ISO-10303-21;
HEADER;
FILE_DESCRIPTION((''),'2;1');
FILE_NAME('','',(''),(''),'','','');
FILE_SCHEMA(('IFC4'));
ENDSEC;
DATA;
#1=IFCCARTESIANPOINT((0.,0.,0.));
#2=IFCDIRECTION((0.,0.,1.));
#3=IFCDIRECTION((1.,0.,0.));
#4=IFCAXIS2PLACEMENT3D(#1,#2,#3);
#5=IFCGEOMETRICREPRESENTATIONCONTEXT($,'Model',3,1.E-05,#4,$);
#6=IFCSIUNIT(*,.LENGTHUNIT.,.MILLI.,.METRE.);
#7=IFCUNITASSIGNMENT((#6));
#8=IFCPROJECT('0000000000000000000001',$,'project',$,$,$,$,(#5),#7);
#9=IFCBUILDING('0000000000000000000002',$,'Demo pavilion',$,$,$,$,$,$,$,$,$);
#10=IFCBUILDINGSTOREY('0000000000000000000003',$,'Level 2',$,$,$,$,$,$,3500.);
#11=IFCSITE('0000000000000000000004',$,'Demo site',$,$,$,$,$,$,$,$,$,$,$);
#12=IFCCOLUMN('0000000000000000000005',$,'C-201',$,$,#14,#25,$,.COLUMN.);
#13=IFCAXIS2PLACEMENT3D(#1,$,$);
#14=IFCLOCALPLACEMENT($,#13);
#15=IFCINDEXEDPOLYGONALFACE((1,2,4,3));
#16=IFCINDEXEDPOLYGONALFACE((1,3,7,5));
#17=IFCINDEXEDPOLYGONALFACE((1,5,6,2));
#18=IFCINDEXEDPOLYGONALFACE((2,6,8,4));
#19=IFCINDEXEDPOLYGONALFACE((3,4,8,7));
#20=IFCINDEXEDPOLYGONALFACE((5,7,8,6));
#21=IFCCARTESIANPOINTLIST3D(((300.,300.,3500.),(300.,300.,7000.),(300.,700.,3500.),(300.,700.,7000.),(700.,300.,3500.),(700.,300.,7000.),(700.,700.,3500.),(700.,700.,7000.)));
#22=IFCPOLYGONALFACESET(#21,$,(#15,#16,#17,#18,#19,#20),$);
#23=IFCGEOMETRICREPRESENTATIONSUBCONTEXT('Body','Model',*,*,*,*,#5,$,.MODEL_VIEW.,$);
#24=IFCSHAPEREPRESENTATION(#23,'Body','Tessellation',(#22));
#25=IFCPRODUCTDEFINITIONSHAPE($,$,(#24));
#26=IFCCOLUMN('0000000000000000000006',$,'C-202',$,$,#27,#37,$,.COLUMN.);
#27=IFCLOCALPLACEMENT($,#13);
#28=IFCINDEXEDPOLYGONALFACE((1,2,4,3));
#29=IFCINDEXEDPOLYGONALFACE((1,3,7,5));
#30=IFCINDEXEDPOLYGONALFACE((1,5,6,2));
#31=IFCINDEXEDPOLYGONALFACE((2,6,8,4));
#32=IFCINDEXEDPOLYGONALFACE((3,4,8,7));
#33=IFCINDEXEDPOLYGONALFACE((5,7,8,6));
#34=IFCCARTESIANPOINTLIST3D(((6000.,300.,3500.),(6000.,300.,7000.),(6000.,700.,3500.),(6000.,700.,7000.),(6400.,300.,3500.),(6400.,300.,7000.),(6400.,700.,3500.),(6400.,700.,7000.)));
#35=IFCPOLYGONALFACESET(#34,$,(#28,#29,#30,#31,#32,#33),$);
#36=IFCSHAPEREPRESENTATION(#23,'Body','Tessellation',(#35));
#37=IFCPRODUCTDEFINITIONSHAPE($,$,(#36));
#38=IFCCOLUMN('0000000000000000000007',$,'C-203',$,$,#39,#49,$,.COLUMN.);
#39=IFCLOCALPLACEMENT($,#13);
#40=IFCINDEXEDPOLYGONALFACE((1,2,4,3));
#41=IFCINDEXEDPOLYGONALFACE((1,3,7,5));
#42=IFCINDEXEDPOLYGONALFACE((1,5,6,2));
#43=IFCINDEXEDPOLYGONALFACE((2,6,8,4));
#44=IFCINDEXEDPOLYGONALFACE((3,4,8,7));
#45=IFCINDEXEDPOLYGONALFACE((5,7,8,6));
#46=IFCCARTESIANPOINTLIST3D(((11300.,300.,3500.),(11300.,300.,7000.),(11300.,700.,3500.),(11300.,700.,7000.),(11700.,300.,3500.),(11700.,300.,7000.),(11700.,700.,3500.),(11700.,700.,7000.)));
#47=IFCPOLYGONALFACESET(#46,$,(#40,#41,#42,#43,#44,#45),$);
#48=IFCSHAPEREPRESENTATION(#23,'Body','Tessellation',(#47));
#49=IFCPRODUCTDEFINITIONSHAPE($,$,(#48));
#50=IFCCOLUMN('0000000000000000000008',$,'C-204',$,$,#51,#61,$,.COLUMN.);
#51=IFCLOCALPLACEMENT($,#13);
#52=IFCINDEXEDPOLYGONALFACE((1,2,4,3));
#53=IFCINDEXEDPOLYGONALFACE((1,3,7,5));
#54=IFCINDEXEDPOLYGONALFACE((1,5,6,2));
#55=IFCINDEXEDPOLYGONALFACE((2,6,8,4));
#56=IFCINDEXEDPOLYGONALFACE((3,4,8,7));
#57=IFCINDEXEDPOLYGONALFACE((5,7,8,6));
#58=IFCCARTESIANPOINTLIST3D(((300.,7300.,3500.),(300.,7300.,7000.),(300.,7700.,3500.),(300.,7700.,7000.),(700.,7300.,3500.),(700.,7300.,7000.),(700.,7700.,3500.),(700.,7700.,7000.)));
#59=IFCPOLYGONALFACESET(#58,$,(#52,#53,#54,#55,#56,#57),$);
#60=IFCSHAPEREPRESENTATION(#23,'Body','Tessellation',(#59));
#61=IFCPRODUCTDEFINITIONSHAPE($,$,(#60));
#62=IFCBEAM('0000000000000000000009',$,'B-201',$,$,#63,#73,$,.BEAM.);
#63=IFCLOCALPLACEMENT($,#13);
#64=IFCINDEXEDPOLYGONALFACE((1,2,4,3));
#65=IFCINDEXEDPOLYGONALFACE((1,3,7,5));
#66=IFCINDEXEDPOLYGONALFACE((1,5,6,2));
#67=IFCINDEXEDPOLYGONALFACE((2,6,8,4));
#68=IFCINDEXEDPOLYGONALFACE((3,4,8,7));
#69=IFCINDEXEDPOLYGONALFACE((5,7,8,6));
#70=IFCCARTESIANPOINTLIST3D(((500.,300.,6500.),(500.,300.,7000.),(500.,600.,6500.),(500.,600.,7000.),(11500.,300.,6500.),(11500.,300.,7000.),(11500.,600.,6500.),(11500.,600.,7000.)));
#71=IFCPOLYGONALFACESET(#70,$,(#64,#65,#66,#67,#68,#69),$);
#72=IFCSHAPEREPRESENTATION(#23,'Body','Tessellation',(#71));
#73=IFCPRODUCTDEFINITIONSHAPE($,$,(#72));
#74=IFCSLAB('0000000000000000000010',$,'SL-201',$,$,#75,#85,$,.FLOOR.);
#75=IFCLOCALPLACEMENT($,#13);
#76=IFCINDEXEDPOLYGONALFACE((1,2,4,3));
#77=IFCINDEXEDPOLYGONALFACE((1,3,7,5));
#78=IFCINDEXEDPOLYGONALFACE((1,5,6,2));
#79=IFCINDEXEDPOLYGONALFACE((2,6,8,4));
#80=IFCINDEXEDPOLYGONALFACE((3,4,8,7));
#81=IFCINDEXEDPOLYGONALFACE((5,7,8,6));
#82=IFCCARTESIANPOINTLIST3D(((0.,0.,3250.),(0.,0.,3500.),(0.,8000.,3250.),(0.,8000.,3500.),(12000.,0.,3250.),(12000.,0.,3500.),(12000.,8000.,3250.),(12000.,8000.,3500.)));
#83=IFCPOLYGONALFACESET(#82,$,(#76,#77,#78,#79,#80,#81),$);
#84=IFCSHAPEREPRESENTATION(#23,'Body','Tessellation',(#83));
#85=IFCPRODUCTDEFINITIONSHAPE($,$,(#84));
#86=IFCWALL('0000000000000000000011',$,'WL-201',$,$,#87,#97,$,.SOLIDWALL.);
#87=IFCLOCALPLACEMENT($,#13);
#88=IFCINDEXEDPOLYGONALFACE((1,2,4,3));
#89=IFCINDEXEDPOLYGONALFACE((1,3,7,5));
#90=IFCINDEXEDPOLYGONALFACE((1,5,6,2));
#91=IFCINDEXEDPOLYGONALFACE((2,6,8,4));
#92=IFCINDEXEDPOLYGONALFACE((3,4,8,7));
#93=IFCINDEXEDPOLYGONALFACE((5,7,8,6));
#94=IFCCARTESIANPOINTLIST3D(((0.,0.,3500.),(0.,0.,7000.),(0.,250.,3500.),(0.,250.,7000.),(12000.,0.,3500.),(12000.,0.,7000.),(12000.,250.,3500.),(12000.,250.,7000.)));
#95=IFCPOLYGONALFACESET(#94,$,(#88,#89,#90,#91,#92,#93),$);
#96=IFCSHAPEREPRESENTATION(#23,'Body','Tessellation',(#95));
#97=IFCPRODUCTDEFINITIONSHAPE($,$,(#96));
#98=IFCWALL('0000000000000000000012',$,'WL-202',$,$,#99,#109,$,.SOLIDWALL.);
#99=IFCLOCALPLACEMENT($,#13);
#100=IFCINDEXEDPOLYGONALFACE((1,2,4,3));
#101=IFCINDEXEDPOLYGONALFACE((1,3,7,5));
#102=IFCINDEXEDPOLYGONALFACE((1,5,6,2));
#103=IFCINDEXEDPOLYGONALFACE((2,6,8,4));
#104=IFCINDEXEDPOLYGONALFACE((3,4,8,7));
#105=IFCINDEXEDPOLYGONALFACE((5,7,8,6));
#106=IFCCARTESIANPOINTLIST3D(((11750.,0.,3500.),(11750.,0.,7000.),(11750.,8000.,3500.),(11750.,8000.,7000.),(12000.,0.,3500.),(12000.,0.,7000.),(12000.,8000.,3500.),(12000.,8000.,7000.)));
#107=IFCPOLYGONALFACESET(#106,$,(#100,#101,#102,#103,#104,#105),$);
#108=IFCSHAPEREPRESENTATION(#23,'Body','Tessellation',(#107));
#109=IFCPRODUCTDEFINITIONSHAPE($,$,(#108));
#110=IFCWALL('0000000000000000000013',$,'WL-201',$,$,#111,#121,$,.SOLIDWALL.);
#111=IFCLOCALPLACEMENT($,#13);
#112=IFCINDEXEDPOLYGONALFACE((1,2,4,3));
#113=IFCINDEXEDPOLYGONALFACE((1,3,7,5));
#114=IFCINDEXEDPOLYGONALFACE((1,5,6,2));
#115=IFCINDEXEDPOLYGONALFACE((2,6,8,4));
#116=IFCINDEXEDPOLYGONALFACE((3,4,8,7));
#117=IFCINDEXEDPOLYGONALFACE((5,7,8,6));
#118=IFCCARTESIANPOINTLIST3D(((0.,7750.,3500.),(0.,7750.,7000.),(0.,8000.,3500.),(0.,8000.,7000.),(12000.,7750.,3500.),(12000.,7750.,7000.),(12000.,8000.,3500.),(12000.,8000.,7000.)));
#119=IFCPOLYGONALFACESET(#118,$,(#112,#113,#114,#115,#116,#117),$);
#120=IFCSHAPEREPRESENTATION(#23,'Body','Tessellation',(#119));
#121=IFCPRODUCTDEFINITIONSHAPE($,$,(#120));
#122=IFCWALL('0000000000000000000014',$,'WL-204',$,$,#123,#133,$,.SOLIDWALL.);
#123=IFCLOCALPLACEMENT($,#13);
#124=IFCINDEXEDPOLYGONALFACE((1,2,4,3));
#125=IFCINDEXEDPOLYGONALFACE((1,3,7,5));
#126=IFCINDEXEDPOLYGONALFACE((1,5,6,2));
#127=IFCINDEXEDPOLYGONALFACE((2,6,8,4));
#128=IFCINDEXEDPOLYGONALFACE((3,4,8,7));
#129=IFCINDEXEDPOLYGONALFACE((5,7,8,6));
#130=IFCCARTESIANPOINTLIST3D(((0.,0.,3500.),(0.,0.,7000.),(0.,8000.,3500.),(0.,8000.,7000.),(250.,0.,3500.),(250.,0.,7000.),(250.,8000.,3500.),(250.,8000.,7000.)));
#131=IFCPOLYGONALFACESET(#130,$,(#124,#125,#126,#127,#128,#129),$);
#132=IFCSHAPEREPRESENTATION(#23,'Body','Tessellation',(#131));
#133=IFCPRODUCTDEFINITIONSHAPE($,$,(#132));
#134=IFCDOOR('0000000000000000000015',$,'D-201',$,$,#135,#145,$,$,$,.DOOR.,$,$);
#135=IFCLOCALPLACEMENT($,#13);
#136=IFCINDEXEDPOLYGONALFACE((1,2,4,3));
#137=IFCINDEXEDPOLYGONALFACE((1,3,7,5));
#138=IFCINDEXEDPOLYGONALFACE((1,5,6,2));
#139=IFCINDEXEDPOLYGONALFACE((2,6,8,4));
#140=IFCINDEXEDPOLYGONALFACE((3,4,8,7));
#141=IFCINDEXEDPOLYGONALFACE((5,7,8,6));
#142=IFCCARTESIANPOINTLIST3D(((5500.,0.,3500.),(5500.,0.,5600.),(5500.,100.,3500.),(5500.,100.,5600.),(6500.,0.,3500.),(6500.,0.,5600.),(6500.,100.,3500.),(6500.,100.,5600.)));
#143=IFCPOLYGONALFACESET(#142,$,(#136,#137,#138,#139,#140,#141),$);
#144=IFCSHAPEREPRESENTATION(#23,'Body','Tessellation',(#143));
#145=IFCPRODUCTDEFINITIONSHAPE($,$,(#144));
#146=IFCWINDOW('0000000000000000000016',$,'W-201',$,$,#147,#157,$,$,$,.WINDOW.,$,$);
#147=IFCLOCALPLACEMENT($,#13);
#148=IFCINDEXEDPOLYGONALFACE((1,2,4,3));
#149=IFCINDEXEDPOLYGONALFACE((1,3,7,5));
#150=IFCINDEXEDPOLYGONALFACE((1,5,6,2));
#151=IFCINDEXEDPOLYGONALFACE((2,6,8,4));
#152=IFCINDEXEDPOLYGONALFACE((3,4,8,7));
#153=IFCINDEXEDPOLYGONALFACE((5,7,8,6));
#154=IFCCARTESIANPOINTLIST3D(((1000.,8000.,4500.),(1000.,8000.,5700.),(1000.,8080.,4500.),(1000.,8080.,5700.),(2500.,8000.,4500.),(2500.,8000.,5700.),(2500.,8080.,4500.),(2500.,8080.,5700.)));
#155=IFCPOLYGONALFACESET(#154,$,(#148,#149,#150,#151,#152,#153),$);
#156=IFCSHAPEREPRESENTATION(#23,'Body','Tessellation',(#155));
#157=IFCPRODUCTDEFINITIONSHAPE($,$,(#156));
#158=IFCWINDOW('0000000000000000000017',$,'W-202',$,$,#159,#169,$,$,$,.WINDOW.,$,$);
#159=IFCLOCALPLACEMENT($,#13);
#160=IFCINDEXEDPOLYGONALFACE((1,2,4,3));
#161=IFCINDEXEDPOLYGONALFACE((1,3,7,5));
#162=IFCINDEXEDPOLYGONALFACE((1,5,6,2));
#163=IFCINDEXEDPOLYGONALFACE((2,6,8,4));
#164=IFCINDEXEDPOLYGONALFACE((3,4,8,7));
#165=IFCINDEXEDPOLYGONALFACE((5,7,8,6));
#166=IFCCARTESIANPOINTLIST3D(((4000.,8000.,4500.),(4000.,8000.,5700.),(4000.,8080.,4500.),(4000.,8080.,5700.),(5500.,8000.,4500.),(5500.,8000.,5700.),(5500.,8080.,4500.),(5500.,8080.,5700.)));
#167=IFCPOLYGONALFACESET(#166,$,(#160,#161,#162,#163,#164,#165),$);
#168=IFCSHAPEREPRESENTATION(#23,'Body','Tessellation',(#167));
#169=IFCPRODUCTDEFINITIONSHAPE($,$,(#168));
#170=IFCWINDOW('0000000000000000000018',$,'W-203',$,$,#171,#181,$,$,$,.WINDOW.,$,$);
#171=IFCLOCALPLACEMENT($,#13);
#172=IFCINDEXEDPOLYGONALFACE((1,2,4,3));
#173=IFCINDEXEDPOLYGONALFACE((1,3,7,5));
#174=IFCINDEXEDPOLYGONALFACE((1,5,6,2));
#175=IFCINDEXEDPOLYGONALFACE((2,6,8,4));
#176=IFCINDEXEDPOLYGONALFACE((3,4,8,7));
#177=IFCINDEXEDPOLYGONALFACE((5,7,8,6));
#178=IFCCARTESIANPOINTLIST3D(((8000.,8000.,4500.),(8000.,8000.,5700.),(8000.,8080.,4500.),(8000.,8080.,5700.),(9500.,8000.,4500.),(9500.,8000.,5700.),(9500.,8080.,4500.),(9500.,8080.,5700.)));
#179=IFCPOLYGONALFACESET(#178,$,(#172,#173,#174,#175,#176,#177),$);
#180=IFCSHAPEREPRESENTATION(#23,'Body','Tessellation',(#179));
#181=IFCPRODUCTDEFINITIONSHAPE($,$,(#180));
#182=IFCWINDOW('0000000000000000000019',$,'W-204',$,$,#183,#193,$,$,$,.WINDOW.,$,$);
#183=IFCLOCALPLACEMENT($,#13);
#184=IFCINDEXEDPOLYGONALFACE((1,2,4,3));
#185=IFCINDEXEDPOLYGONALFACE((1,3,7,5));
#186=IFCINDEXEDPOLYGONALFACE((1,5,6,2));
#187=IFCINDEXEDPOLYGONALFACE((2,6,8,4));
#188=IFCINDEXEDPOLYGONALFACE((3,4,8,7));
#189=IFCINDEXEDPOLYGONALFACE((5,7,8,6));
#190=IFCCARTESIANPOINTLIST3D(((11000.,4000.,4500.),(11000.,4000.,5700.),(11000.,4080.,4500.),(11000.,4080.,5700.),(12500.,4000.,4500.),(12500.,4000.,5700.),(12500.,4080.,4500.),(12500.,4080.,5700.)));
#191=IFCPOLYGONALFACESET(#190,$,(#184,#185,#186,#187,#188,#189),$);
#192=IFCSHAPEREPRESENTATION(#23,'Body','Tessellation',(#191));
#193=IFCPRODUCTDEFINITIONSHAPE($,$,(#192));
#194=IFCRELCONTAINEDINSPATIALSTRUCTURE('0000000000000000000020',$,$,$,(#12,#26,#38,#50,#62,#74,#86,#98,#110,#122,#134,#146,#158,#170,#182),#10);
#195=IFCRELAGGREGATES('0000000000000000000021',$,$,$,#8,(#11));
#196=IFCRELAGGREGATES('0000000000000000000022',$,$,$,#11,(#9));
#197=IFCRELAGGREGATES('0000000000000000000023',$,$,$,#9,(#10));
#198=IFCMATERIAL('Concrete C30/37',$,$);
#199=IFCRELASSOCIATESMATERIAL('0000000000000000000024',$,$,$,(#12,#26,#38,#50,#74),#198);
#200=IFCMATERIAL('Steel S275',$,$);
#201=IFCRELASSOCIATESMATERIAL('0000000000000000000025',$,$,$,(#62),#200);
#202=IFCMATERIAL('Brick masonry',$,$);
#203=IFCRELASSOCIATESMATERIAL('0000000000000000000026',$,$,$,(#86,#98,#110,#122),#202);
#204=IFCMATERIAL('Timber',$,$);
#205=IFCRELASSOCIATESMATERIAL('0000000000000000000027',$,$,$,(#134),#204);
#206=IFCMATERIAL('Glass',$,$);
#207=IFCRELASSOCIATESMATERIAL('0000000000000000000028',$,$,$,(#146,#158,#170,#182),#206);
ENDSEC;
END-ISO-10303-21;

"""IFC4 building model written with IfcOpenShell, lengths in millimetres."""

from ifc_helpers import new_model, si_unit, frame, origin_with_axes, place, context, subcontext, project, spatial, indexed_curve, outline, extrude, material, element, save


model = new_model("IFC4")

# Units and contexts
model_context = context("Model", 3, precision=1e-05, world=origin_with_axes())
body_context = subcontext(model_context, "Body", "Model", "MODEL_VIEW")
ifc_project = project(units=[si_unit("LENGTHUNIT", "METRE", prefix="MILLI")], contexts=[model_context])

# Site, building, storey
site = spatial("IfcSite", under=ifc_project, Name="Demo site")
building = spatial("IfcBuilding", under=site, Name="Demo pavilion")
storey = spatial("IfcBuildingStorey", under=building, Name="Level 2", Elevation=3500.0)

# Columns
ifc_material_1 = material(Name="Concrete C30/37")
for number, where, z_axis, x_axis, name in (
    (1, (300.0, 300.0, 3500.0), (0.0, 0.0, 1.0), (1.0, 0.0, 0.0), "C-201"),
    (2, (6000.0, 300.0, 3500.0), (0.0, 0.0, 1.0), (1.0, 0.0, 0.0), "C-202"),
    (3, (11300.0, 300.0, 3500.0), (0.0, 0.0, 1.0), (1.0, 0.0, 0.0), "C-203"),
    (4, (300.0, 7300.0, 3500.0), (0.0, 0.0, 1.0), (1.0, 0.0, 0.0), "C-204"),
):
    element("IfcColumn", number, at=place(None, frame(where, z_axis=z_axis, x_axis=x_axis)), inside=storey, material=ifc_material_1, Name=name, PredefinedType="COLUMN", context=body_context, shape_type="SweptSolid", body=[
        extrude(outline(indexed_curve([(0.0, 0.0), (0.0, 400.0), (400.0, 400.0), (400.0, 0.0), (0.0, 0.0)], self_intersect=False)), origin_with_axes(), (0.0, 0.0, 1.0), 3500.0),
    ])

# Beam
ifc_material_2 = material(Name="Steel S275")
beam_placement = place(None, frame((500.0, 300.0, 6500.0), z_axis=(0.0, 0.0, 1.0), x_axis=(1.0, 0.0, 0.0)))
element("IfcBeam", 5, at=beam_placement, inside=storey, material=ifc_material_2, Name="B-201", PredefinedType="BEAM", context=body_context, shape_type="SweptSolid", body=[
    extrude(outline(indexed_curve([(0.0, 0.0), (0.0, 300.0), (11000.0, 300.0), (11000.0, 0.0), (0.0, 0.0)], self_intersect=False)), origin_with_axes(), (0.0, 0.0, 1.0), 500.0),
])

# Slab
slab_placement = place(None, frame((0.0, 0.0, 3250.0), z_axis=(0.0, 0.0, 1.0), x_axis=(1.0, 0.0, 0.0)))
element("IfcSlab", 6, at=slab_placement, inside=storey, material=ifc_material_1, Name="SL-201", PredefinedType="FLOOR", context=body_context, shape_type="SweptSolid", body=[
    extrude(outline(indexed_curve([(0.0, 0.0), (0.0, 8000.0), (12000.0, 8000.0), (12000.0, 0.0), (0.0, 0.0)], self_intersect=False)), origin_with_axes(), (0.0, 0.0, 1.0), 250.0),
])

# Walls
ifc_material_3 = material(Name="Brick masonry")
wall_1_placement = place(None, frame((0.0, 0.0, 3500.0), z_axis=(0.0, 0.0, 1.0), x_axis=(1.0, 0.0, 0.0)))
element("IfcWall", 7, at=wall_1_placement, inside=storey, material=ifc_material_3, Name="WL-201", PredefinedType="SOLIDWALL", context=body_context, shape_type="SweptSolid", body=[
    extrude(outline(indexed_curve([(0.0, 0.0), (0.0, 250.0), (12000.0, 250.0), (12000.0, 0.0), (0.0, 0.0)], self_intersect=False)), origin_with_axes(), (0.0, 0.0, 1.0), 3500.0),
])
wall_2_placement = place(None, frame((12000.0, 0.0, 3500.0), z_axis=(0.0, 0.0, 1.0), x_axis=(0.0, 1.0, 0.0)))
element("IfcWall", 8, at=wall_2_placement, inside=storey, material=ifc_material_3, Name="WL-202", PredefinedType="SOLIDWALL", context=body_context, shape_type="SweptSolid", body=[
    extrude(outline(indexed_curve([(0.0, 0.0), (0.0, 250.0), (8000.0, 250.0), (8000.0, 0.0), (0.0, 0.0)], self_intersect=False)), origin_with_axes(), (0.0, 0.0, 1.0), 3500.0),
])
wall_3_placement = place(None, frame((12000.0, 8000.0, 3500.0), z_axis=(0.0, 0.0, 1.0), x_axis=(-1.0, 0.0, 0.0)))
element("IfcWall", 9, at=wall_3_placement, inside=storey, material=ifc_material_3, Name="WL-201", PredefinedType="SOLIDWALL", context=body_context, shape_type="SweptSolid", body=[
    extrude(outline(indexed_curve([(0.0, 0.0), (0.0, 250.0), (12000.0, 250.0), (12000.0, 0.0), (0.0, 0.0)], self_intersect=False)), origin_with_axes(), (0.0, 0.0, 1.0), 3500.0),
])
wall_4_placement = place(None, frame((0.0, 8000.0, 3500.0), z_axis=(0.0, 0.0, 1.0), x_axis=(0.0, -1.0, 0.0)))
element("IfcWall", 10, at=wall_4_placement, inside=storey, material=ifc_material_3, Name="WL-204", PredefinedType="SOLIDWALL", context=body_context, shape_type="SweptSolid", body=[
    extrude(outline(indexed_curve([(0.0, 0.0), (0.0, 250.0), (8000.0, 250.0), (8000.0, 0.0), (0.0, 0.0)], self_intersect=False)), origin_with_axes(), (0.0, 0.0, 1.0), 3500.0),
])

# Door
ifc_material_4 = material(Name="Timber")
door_placement = place(None, frame((5500.0, 0.0, 3500.0), z_axis=(0.0, 0.0, 1.0), x_axis=(1.0, 0.0, 0.0)))
element("IfcDoor", 11, at=door_placement, inside=storey, material=ifc_material_4, Name="D-201", PredefinedType="DOOR", context=body_context, shape_type="SweptSolid", body=[
    extrude(outline(indexed_curve([(0.0, 0.0), (0.0, 100.0), (1000.0, 100.0), (1000.0, 0.0), (0.0, 0.0)], self_intersect=False)), origin_with_axes(), (0.0, 0.0, 1.0), 2100.0),
])

# Windows
ifc_material_5 = material(Name="Glass")
for number, where, z_axis, x_axis, name in (
    (12, (1000.0, 8000.0, 4500.0), (0.0, 0.0, 1.0), (1.0, 0.0, 0.0), "W-201"),
    (13, (4000.0, 8000.0, 4500.0), (0.0, 0.0, 1.0), (1.0, 0.0, 0.0), "W-202"),
    (14, (8000.0, 8000.0, 4500.0), (0.0, 0.0, 1.0), (1.0, 0.0, 0.0), "W-203"),
    (15, (11000.0, 4000.0, 4500.0), (0.0, 0.0, 1.0), (1.0, 0.0, 0.0), "W-204"),
):
    element("IfcWindow", number, at=place(None, frame(where, z_axis=z_axis, x_axis=x_axis)), inside=storey, material=ifc_material_5, Name=name, PredefinedType="WINDOW", context=body_context, shape_type="SweptSolid", body=[
        extrude(outline(indexed_curve([(0.0, 0.0), (0.0, 80.0), (1500.0, 80.0), (1500.0, 0.0), (0.0, 0.0)], self_intersect=False)), origin_with_axes(), (0.0, 0.0, 1.0), 1200.0),
    ])

save(model, "model.ifc")
